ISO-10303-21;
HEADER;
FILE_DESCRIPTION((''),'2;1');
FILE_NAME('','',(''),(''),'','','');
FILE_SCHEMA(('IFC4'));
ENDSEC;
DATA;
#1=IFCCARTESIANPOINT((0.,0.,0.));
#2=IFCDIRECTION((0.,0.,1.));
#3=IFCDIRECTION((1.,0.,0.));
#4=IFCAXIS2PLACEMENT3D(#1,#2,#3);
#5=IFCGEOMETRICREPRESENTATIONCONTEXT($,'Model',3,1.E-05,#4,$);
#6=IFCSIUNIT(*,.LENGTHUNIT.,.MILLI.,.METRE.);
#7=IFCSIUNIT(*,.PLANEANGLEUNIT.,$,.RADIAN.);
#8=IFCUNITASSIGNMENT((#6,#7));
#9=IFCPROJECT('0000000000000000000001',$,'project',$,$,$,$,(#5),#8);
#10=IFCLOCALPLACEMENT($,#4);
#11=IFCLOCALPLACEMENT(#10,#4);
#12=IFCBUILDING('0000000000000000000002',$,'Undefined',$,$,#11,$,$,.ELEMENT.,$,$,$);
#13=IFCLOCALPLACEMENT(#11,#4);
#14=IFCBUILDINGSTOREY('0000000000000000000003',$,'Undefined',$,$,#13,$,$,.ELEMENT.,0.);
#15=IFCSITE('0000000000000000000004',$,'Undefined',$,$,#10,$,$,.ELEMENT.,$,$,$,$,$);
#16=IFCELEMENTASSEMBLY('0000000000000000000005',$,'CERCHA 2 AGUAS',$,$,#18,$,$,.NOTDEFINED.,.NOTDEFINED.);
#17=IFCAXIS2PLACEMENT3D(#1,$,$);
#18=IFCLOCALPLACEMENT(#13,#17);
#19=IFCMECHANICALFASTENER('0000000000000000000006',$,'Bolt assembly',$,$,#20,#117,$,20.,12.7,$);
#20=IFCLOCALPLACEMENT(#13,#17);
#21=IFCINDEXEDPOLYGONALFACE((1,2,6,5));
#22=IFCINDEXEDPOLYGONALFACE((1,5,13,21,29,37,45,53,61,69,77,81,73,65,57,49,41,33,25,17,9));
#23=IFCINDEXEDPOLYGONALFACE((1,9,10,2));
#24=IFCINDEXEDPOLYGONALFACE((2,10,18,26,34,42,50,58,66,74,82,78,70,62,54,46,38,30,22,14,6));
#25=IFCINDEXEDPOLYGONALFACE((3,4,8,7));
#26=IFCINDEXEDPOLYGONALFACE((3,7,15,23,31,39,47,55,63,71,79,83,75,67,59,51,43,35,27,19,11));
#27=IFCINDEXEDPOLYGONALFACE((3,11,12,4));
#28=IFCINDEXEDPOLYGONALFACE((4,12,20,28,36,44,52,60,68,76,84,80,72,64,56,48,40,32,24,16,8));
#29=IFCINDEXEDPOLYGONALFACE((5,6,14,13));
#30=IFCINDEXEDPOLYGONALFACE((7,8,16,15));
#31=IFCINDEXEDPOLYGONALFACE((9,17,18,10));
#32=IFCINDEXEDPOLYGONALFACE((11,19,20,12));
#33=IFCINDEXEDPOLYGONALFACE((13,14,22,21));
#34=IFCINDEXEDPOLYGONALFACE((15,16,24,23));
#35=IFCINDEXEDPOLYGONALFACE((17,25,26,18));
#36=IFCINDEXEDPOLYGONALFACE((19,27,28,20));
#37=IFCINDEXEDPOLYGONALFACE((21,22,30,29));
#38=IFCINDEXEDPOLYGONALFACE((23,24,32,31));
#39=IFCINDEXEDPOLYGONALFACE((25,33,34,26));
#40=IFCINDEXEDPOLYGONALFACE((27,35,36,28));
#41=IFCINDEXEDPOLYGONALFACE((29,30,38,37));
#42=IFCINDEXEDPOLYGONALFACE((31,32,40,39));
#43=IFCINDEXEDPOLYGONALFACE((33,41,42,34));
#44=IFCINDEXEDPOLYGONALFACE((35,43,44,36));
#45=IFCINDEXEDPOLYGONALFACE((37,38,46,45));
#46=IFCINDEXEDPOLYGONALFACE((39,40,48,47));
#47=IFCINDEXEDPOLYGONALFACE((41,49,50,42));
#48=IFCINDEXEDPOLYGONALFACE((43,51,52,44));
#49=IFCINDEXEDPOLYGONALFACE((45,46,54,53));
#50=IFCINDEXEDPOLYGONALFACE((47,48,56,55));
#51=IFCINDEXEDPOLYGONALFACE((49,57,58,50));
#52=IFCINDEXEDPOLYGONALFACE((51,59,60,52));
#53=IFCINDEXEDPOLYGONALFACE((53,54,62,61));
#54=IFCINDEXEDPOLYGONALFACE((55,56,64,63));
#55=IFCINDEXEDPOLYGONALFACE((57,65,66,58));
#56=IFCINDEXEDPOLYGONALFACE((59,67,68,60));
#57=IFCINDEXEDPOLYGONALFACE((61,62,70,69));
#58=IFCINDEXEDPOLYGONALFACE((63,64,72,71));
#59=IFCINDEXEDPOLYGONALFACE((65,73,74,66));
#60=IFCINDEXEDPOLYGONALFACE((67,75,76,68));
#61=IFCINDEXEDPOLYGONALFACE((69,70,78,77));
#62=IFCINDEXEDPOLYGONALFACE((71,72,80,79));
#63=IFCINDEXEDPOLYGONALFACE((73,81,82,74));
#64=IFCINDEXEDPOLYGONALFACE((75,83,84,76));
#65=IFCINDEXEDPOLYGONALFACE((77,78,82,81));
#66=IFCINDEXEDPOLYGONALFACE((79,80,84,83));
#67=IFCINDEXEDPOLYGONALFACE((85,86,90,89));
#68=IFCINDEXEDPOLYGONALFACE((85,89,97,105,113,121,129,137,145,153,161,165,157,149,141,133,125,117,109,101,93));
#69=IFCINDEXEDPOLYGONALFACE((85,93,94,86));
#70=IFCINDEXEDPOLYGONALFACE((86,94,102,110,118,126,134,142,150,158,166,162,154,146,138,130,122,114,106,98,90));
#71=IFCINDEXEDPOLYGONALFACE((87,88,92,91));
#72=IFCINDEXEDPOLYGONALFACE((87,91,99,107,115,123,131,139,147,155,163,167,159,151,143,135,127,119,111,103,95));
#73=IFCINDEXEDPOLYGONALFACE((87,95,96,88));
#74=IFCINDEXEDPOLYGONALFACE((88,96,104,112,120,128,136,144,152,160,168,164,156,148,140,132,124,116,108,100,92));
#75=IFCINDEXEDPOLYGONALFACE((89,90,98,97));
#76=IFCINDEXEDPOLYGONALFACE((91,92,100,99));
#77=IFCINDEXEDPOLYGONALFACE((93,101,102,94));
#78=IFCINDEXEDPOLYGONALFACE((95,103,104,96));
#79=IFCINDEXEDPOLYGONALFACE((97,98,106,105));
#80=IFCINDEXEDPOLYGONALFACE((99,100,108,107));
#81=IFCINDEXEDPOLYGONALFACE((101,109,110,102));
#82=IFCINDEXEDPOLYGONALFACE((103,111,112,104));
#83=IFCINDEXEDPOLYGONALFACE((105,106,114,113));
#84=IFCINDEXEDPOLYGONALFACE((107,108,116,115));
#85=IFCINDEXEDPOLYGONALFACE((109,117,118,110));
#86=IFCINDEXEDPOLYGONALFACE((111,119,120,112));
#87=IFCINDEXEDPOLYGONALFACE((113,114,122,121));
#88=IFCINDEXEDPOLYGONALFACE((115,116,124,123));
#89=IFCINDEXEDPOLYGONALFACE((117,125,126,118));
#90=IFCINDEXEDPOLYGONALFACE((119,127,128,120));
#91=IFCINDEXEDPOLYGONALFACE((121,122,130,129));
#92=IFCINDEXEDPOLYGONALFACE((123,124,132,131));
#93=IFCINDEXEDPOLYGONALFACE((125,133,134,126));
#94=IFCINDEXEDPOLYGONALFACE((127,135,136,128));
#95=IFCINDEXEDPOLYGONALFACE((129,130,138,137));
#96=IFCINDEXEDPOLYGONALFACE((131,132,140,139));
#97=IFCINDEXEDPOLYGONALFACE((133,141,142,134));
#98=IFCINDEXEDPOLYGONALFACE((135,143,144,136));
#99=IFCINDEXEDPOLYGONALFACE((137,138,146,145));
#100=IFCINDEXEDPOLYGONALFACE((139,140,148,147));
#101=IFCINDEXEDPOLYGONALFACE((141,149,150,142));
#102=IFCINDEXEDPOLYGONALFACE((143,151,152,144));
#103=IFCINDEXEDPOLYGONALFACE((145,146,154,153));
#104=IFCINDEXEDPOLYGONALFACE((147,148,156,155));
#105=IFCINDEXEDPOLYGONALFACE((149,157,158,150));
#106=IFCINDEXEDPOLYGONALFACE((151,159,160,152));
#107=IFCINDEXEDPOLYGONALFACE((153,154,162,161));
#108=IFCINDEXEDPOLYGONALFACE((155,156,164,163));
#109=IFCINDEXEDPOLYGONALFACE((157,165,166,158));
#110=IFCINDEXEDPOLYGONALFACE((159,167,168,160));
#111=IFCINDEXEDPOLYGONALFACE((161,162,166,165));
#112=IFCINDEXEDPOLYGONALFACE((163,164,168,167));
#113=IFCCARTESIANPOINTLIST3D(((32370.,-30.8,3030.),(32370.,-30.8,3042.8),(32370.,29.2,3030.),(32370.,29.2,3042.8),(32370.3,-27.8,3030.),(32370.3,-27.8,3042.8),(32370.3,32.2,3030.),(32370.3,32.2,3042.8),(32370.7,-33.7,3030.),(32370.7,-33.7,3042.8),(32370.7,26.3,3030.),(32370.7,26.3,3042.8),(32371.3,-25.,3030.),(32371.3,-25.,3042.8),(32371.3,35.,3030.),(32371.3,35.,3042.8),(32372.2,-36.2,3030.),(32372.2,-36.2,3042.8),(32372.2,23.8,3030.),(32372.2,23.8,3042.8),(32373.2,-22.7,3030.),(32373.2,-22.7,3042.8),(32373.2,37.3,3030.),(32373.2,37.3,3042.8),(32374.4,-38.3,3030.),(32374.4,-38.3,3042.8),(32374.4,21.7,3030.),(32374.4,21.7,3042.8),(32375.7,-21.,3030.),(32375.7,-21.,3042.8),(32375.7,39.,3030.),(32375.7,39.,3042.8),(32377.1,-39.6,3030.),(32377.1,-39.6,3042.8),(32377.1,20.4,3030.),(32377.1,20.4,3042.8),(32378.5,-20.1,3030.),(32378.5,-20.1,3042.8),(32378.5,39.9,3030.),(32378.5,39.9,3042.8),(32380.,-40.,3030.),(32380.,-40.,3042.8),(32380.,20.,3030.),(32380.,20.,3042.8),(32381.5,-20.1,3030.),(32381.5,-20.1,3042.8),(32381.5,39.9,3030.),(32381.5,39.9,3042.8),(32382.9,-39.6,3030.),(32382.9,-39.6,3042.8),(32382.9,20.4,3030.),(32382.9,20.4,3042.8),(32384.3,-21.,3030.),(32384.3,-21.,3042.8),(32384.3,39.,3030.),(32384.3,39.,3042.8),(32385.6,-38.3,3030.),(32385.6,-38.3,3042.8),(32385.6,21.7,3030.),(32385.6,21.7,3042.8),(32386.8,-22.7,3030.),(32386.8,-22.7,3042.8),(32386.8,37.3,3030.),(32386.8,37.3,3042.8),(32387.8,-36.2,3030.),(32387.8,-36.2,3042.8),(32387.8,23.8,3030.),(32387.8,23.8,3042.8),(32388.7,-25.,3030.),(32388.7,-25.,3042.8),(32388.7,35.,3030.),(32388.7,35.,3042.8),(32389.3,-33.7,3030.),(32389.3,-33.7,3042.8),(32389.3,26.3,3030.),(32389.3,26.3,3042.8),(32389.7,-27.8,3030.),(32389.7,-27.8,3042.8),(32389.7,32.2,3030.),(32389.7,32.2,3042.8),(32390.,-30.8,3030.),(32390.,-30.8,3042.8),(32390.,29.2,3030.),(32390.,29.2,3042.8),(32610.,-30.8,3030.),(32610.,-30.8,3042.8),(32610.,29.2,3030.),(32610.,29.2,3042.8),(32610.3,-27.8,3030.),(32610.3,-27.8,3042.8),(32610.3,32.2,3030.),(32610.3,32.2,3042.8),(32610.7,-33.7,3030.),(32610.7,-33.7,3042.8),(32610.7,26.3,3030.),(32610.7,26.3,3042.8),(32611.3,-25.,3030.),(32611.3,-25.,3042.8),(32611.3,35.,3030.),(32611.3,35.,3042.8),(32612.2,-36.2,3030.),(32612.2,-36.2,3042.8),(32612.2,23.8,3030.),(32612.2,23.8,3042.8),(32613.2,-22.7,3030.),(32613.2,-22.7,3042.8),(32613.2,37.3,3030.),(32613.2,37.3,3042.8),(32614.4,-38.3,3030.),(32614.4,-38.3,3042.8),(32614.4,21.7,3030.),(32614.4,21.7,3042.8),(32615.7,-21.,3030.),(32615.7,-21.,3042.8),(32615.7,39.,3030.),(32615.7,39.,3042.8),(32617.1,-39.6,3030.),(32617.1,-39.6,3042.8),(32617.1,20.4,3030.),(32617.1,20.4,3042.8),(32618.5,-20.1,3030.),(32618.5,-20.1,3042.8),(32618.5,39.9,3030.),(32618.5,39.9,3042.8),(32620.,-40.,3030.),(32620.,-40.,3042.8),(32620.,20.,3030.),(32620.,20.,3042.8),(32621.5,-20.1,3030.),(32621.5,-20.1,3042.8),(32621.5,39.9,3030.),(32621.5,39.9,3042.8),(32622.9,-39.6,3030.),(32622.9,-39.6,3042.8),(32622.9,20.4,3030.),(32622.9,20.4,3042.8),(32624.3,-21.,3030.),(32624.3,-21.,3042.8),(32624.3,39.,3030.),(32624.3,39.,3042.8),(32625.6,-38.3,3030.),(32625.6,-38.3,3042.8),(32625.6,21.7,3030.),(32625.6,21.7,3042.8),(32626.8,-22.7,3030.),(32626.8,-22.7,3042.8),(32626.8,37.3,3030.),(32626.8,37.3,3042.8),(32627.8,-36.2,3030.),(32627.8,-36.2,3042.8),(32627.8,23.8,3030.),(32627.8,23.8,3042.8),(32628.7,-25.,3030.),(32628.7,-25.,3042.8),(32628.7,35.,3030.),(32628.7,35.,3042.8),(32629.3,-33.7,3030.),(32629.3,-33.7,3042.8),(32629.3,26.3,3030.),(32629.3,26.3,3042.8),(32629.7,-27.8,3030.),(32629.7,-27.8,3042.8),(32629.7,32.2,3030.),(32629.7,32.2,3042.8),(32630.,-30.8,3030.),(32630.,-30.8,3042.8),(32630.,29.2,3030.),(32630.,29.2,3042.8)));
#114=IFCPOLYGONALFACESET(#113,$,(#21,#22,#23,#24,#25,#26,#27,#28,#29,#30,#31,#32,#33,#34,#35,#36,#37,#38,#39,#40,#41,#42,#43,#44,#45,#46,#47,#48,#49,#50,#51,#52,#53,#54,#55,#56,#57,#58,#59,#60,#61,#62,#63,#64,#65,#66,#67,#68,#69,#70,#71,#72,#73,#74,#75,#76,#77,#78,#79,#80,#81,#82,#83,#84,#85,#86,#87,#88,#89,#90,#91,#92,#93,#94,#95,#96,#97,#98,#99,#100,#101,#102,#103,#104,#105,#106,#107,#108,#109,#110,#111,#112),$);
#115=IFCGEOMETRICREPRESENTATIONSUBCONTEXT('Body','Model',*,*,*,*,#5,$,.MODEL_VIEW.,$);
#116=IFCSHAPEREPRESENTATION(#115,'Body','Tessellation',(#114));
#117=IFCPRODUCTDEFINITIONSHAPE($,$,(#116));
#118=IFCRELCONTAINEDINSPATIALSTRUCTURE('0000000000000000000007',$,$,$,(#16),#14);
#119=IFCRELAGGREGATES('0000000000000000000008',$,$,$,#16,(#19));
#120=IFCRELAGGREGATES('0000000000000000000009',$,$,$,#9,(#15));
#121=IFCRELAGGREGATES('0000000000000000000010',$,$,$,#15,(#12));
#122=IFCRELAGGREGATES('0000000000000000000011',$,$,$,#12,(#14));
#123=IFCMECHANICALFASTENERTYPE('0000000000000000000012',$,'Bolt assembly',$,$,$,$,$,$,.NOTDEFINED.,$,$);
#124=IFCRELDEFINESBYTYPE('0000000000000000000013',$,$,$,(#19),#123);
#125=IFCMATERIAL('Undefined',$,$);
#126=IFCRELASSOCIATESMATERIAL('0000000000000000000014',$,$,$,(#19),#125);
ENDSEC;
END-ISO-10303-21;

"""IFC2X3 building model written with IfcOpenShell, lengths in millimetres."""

from ifc_helpers import new_model, si_unit, frame, origin_with_axes, origin_2d_with_axis, place, context, subcontext, project, spatial, circle, extrude, source, transform, mapped, material, type_object, element, aggregate, save


model = new_model("IFC2X3")

# Units and contexts
model_context = context("Model", 3, precision=1e-05, world=origin_with_axes())
body_context = subcontext(model_context, "Body", "Model", "MODEL_VIEW")
ifc_project = project(units=[si_unit("LENGTHUNIT", "METRE", prefix="MILLI"), si_unit("PLANEANGLEUNIT", "RADIAN")], contexts=[model_context])

# Site, building, storey
site_placement = place(None, origin_with_axes())
site = spatial("IfcSite", under=ifc_project, at=site_placement, Name="Undefined", CompositionType="ELEMENT")
building_placement = place(site_placement, origin_with_axes())
building = spatial("IfcBuilding", under=site, at=building_placement, Name="Undefined", CompositionType="ELEMENT")
storey_placement = place(building_placement, origin_with_axes())
storey = spatial("IfcBuildingStorey", under=building, at=storey_placement, Name="Undefined", CompositionType="ELEMENT", Elevation=0.0)

# Element assembly
assembly_1_placement = place(storey_placement, origin_with_axes())
assembly_1 = element("IfcElementAssembly", 1, at=assembly_1_placement, inside=storey, Name="CERCHA 2 AGUAS", AssemblyPlace="NOTDEFINED", PredefinedType="NOTDEFINED")

# Shared definitions
ifc_material_1 = material(Name="Undefined")
mechanical_fastener_type = type_object("IfcMechanicalFastenerType", Name="Bolt assembly")

# Mechanical fastener
shared_shape_1 = source(origin_with_axes(), body_context, "Body", "SweptSolid", [
    extrude(circle(Radius=10.0, at=origin_2d_with_axis()), frame((0.0, -12.7, 0.0), z_axis=(0.0, 1.0, 0.0), x_axis=(1.0, 0.0, 0.0)), (0.0, 0.0, 1.0), 12.8),
])
mechanical_fastener_1_placement = place(assembly_1_placement, frame((32500.0, 30.0, 3042.7), z_axis=(-1.0, 0.0, 0.0), x_axis=(0.0, -1.0, 0.0)))
mechanical_fastener_1 = element("IfcMechanicalFastener", 2, at=mechanical_fastener_1_placement, type_object=mechanical_fastener_type, material=ifc_material_1, Name="Bolt assembly", NominalDiameter=20.0, NominalLength=12.7, context=body_context, shape_type="MappedRepresentation", body=[
    mapped(shared_shape_1, transform((0.0, 0.0, -120.0))),
    mapped(shared_shape_1, transform((60.0, 0.0, -120.0))),
    mapped(shared_shape_1, transform((0.0, 0.0, 120.0))),
    mapped(shared_shape_1, transform((60.0, 0.0, 120.0))),
])
aggregate(assembly_1, [mechanical_fastener_1])

save(model, "model.ifc")
